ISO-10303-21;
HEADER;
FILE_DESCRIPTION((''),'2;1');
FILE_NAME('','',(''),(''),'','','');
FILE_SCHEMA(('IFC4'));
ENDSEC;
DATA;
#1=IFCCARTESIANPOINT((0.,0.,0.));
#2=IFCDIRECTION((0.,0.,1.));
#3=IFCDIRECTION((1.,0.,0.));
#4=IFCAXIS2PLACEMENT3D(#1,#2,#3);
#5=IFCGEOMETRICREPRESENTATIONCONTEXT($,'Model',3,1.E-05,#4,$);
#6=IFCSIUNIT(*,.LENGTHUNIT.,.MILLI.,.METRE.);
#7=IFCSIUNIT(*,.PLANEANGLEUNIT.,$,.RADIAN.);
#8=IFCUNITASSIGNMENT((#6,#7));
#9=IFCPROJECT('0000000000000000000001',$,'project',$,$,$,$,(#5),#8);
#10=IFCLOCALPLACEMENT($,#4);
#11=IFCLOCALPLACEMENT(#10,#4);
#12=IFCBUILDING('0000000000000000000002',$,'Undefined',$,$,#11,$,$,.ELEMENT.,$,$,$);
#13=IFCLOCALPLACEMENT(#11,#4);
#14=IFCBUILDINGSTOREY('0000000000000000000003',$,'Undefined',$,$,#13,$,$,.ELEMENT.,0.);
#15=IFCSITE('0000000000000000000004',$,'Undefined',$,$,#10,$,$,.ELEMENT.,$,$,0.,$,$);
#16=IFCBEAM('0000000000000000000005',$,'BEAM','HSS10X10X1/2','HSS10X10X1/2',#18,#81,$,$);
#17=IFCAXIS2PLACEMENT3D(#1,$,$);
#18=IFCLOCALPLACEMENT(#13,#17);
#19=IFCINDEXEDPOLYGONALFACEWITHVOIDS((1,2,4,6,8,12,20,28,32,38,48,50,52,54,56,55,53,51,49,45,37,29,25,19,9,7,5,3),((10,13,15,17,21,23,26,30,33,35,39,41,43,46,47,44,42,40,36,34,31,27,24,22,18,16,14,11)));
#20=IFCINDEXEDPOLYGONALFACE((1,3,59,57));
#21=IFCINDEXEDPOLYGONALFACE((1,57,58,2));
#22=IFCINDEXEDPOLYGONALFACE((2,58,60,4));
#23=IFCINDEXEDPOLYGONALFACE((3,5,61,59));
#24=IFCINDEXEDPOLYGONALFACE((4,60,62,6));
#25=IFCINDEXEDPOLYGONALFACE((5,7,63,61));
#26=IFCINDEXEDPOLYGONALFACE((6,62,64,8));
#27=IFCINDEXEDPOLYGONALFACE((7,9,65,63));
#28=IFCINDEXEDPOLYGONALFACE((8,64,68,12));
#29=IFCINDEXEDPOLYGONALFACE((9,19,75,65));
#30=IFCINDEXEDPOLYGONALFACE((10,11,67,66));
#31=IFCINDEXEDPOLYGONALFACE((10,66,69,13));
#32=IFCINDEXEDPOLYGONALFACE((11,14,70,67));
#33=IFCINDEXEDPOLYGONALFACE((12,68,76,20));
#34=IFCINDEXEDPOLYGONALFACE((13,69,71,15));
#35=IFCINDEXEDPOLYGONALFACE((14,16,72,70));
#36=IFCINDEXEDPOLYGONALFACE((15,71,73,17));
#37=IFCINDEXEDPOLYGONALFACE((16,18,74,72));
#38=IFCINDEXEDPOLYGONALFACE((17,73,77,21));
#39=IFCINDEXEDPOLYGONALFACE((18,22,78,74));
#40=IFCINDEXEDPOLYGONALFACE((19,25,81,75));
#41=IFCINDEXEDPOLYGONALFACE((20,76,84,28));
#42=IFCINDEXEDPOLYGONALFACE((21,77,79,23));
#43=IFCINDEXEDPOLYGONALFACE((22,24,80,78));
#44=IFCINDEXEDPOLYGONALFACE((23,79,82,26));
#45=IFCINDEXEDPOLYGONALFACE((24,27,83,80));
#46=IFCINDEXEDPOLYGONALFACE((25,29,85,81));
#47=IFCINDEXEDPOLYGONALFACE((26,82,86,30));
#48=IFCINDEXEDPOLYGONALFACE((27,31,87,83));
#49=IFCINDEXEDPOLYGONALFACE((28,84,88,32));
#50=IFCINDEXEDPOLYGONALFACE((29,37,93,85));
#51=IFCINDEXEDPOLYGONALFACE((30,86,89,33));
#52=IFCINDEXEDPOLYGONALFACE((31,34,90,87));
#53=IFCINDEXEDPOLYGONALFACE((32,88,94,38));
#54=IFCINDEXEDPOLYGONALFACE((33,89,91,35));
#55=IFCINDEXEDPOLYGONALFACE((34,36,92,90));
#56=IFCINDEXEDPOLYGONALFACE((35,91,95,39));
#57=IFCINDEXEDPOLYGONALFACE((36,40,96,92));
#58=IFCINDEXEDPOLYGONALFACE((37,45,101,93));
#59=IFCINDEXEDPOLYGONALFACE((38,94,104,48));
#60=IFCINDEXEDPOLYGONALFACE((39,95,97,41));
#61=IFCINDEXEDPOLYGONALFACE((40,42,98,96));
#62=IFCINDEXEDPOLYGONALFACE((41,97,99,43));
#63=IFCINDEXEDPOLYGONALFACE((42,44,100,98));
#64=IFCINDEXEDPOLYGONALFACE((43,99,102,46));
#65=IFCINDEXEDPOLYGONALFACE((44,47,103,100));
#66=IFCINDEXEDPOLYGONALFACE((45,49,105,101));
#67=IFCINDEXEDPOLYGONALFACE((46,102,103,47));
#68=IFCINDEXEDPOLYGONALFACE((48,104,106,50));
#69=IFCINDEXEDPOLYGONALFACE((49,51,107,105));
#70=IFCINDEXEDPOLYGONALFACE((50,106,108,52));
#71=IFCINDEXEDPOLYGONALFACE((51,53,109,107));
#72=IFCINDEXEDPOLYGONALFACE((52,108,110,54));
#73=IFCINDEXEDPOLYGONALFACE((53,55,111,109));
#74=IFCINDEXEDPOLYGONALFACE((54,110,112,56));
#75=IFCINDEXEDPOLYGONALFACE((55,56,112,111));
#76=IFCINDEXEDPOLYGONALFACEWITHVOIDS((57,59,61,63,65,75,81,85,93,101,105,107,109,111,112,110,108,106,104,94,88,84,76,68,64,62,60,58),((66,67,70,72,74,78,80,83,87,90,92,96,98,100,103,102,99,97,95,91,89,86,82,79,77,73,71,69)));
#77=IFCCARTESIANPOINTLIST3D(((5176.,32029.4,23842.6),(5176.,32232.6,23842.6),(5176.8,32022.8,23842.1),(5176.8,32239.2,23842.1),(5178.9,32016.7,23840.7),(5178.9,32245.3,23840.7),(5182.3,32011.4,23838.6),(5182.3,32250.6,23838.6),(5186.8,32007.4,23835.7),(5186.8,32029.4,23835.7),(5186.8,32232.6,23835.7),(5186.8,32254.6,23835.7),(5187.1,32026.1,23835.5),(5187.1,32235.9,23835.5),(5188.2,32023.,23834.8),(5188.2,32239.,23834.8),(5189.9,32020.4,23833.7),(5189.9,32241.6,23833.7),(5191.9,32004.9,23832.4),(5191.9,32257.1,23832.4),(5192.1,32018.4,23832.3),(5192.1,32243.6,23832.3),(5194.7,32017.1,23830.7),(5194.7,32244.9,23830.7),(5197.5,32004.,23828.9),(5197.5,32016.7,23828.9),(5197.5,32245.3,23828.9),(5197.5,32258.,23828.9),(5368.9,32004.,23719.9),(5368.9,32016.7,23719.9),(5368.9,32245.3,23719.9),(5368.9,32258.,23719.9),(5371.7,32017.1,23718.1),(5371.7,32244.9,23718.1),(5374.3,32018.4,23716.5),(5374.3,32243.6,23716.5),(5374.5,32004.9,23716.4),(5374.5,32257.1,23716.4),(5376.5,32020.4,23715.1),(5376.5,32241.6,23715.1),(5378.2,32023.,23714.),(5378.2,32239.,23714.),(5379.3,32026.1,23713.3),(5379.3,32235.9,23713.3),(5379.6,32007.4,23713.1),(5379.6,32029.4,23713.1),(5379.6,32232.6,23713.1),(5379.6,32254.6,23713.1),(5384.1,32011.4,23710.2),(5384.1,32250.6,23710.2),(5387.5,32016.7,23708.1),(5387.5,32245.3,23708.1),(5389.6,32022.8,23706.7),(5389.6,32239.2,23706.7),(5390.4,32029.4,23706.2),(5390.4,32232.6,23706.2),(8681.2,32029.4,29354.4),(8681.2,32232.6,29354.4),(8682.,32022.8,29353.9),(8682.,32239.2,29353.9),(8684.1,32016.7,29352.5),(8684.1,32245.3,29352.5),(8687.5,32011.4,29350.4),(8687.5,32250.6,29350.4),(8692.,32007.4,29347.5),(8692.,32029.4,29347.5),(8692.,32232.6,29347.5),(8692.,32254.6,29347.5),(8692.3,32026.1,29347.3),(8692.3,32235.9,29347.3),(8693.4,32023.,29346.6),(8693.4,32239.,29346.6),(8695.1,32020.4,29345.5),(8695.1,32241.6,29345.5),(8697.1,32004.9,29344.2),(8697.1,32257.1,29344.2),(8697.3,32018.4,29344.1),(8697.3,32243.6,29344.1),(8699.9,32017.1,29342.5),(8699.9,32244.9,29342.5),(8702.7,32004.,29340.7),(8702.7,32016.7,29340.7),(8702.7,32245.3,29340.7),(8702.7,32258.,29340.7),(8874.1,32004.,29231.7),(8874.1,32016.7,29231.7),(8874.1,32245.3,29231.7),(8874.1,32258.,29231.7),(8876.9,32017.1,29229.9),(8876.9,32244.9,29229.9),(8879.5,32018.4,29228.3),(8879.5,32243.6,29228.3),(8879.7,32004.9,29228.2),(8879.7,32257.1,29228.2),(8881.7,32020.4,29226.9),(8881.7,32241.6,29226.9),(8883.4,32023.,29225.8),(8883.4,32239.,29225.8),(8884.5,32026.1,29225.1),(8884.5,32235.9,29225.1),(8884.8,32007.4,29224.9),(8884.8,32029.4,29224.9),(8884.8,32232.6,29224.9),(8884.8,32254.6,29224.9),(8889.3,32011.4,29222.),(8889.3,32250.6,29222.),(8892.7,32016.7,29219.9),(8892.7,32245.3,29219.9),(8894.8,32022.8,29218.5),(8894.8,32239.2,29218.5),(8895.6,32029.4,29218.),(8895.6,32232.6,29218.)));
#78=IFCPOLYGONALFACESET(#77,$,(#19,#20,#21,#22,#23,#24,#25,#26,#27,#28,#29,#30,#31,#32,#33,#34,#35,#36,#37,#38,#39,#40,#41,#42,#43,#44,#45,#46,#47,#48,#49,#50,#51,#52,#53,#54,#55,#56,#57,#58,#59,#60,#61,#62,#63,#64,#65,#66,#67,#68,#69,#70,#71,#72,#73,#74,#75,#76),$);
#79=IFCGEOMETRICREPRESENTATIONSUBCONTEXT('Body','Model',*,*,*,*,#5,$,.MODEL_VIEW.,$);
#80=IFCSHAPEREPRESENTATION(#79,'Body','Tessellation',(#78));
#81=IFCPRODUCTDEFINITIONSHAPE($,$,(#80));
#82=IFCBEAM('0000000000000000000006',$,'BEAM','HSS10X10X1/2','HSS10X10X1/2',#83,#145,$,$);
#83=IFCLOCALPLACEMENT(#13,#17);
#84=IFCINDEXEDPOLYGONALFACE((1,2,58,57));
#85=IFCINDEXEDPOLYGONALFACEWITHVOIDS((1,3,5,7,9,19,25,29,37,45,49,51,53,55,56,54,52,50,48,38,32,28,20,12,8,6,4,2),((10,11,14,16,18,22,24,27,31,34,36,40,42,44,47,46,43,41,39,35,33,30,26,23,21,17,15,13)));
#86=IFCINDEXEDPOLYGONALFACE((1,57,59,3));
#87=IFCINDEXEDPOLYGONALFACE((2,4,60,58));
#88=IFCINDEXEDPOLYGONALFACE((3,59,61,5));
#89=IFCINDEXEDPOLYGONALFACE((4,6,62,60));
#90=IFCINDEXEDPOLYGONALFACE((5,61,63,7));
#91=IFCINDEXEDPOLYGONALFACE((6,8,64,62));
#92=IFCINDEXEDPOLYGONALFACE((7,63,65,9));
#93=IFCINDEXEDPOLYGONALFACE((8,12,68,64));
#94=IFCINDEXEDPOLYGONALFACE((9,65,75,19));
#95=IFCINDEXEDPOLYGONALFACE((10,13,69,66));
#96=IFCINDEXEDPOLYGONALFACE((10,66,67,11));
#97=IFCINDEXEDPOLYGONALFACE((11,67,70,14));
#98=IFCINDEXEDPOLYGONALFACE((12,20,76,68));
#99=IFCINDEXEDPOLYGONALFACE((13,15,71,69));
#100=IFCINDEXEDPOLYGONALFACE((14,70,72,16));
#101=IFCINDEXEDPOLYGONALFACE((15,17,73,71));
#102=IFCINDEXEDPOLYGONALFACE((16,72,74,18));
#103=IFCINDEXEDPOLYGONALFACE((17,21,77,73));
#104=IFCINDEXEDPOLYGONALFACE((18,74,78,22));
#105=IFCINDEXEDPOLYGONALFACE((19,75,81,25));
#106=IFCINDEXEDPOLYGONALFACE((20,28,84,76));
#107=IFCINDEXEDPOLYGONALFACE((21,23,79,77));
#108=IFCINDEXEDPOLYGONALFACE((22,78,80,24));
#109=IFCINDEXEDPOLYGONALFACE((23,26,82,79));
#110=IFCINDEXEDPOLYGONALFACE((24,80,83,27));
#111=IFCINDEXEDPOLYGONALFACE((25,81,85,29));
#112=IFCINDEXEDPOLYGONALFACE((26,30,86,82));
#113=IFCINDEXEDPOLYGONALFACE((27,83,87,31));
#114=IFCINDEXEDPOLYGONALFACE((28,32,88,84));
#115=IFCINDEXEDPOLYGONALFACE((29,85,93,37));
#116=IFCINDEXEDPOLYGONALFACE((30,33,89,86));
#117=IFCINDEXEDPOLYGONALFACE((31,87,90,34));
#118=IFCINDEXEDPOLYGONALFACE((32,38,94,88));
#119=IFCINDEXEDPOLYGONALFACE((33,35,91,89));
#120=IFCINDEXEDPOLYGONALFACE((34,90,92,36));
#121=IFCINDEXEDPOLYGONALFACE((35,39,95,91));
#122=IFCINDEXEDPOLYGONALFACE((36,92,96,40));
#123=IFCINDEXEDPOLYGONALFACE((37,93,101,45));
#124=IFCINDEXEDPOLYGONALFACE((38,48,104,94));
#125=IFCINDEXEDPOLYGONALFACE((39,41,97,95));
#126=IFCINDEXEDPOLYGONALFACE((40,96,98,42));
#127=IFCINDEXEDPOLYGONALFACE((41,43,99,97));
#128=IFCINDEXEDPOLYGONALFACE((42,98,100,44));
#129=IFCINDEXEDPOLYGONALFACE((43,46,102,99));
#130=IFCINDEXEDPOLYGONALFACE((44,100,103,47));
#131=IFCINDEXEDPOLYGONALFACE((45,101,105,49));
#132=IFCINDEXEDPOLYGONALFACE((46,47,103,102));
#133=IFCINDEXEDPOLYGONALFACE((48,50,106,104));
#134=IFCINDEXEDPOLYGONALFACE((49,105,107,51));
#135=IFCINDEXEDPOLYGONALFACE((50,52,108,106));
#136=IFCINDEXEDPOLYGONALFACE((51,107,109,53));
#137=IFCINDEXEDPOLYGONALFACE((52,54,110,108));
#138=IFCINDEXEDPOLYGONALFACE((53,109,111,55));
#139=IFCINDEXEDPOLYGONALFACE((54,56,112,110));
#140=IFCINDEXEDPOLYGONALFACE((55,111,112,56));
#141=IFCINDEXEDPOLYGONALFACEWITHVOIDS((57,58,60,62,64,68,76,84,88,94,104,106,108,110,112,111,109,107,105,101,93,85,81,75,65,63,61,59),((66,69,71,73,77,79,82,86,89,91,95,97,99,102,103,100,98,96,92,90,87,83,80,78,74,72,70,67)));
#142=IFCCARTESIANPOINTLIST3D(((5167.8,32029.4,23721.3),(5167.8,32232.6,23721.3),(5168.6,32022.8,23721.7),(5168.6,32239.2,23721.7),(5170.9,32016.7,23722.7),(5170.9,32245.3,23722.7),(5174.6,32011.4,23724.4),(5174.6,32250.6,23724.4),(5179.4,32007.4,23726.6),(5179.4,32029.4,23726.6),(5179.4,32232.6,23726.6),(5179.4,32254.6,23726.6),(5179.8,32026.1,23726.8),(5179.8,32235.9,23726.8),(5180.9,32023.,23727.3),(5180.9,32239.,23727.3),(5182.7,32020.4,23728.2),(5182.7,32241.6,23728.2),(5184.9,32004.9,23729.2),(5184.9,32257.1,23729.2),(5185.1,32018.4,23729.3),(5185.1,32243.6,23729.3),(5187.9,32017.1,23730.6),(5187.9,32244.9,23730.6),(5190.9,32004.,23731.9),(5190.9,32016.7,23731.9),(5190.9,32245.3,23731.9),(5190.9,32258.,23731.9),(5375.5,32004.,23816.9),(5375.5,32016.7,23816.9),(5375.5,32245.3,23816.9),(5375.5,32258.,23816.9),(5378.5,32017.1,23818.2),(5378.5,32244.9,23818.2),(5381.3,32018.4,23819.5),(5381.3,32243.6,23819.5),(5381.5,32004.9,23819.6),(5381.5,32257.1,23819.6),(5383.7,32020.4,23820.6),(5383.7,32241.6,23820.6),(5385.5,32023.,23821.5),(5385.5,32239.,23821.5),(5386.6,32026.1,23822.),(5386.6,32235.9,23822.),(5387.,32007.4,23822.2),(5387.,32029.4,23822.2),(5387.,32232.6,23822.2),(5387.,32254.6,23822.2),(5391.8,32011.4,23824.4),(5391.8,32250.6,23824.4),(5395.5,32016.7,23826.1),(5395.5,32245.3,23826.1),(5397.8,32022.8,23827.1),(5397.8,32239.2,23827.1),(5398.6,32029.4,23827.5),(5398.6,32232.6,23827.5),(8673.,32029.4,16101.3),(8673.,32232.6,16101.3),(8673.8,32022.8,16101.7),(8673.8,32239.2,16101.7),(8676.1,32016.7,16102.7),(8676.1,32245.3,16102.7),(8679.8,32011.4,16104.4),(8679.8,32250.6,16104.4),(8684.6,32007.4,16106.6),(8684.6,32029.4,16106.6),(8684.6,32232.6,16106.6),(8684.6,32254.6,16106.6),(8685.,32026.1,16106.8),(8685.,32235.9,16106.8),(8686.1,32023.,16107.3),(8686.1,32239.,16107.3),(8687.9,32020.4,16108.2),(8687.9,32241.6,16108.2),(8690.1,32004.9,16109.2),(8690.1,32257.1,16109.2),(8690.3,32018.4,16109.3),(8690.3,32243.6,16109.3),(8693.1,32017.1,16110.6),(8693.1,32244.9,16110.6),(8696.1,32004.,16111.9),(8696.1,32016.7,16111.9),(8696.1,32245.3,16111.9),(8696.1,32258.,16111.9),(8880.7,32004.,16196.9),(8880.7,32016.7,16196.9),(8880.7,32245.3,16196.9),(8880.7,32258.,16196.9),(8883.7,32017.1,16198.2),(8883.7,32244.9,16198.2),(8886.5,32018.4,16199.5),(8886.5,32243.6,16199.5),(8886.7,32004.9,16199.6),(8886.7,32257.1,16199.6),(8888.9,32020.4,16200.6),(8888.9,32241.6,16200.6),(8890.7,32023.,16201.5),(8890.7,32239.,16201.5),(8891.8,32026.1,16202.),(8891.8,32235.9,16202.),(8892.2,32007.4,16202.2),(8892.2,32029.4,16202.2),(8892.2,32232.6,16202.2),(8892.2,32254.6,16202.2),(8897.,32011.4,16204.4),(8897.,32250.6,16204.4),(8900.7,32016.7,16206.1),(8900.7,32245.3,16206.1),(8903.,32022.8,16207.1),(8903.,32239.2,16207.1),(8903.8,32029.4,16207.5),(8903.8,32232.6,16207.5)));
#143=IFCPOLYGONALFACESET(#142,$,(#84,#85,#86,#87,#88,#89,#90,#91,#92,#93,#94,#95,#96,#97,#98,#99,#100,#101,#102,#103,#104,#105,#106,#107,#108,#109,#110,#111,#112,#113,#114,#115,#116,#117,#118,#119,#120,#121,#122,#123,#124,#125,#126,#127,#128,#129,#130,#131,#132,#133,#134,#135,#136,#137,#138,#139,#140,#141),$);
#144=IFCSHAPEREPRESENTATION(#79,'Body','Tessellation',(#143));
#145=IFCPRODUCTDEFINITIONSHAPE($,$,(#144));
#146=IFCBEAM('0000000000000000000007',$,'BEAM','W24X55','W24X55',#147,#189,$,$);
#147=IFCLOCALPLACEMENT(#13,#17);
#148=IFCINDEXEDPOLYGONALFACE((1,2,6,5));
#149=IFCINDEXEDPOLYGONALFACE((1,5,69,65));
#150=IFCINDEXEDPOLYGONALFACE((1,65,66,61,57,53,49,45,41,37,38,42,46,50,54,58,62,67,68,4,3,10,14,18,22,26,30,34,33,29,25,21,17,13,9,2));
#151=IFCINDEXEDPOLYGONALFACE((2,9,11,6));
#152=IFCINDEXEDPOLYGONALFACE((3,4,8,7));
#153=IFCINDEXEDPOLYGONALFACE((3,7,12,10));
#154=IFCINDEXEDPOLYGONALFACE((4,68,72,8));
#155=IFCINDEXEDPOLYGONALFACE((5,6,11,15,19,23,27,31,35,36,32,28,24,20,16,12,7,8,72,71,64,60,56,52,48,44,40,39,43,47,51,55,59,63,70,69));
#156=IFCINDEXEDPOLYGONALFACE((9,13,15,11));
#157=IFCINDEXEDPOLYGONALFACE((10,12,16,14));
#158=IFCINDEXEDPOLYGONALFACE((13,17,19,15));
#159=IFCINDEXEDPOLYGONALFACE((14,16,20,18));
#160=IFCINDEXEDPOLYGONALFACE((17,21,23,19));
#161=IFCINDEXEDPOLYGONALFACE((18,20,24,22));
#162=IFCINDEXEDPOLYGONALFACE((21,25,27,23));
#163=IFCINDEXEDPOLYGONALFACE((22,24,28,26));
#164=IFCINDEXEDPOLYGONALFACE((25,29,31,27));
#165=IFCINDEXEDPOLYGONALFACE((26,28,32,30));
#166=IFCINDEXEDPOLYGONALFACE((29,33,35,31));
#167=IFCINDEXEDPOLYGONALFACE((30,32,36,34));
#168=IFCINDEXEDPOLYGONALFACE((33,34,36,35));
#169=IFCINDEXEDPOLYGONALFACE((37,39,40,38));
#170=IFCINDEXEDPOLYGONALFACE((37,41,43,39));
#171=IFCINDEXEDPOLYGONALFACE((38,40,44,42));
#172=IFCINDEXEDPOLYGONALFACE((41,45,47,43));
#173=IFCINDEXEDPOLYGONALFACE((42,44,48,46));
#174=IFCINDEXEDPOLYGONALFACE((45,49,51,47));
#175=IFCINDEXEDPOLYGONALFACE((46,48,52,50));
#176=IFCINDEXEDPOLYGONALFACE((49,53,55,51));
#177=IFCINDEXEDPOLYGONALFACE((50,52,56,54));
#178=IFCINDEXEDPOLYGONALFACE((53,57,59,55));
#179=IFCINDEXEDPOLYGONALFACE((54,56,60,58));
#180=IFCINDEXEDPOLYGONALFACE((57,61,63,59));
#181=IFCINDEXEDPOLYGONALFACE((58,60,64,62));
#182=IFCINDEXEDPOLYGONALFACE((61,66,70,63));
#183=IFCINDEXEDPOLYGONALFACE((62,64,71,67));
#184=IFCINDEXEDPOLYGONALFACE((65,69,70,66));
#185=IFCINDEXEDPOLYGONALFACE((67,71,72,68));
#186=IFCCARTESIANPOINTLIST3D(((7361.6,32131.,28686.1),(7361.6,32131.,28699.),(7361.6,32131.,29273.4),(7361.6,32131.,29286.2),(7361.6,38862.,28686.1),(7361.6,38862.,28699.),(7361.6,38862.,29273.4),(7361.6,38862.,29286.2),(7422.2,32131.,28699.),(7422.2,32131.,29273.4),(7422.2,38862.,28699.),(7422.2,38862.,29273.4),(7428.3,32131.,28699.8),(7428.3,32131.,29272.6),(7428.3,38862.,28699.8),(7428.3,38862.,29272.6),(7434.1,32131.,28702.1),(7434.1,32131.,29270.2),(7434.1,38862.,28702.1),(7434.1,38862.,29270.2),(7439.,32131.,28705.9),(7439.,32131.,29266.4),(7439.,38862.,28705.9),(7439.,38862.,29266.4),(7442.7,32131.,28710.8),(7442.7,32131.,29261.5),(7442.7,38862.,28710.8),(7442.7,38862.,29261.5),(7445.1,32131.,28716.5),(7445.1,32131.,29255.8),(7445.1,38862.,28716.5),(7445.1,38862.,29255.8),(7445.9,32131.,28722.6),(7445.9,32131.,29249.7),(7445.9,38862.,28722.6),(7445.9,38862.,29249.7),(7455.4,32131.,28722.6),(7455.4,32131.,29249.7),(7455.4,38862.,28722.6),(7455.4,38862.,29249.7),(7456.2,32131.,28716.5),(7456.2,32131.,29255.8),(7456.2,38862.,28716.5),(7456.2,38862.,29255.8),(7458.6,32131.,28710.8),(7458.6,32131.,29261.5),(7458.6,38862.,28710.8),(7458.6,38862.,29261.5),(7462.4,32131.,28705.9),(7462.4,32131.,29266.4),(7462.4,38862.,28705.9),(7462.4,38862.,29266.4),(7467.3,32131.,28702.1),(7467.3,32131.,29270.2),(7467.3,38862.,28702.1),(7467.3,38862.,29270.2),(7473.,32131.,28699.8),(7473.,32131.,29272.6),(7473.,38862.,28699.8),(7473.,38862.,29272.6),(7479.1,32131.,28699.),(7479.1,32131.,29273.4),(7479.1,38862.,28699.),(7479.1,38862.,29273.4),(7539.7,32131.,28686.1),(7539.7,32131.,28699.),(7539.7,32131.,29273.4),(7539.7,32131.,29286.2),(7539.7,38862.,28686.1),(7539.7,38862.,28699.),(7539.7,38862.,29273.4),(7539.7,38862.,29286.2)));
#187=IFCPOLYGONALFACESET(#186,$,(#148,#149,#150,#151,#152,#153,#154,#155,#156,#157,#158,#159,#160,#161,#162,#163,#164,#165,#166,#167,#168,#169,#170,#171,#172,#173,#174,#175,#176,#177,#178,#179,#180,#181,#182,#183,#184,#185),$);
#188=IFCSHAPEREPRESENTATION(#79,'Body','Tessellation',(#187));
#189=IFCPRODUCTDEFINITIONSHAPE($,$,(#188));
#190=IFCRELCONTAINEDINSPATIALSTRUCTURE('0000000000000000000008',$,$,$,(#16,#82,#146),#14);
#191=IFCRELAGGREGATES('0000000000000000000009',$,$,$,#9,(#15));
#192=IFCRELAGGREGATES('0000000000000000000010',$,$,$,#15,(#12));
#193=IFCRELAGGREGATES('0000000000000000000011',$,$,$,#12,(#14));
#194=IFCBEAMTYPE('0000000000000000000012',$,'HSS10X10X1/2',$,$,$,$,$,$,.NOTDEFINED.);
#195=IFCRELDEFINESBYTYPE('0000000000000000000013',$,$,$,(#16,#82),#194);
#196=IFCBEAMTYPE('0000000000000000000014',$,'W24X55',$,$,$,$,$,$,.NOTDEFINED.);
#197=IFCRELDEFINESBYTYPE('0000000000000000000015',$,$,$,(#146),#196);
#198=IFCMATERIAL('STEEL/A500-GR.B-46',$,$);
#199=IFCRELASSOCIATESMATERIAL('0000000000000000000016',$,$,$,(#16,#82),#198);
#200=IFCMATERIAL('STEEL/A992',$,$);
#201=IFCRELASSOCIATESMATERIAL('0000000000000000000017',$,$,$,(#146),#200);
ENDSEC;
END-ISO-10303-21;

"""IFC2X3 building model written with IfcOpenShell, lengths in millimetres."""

from ifc_helpers import new_model, si_unit, frame, origin_with_axes, origin_2d_with_axis, place, context, subcontext, project, spatial, hollow_rectangle, i_section, extrude, material, type_object, element, save


model = new_model("IFC2X3")

# Units and contexts
model_context = context("Model", 3, precision=1e-05, world=origin_with_axes())
body_context = subcontext(model_context, "Body", "Model", "MODEL_VIEW")
ifc_project = project(units=[si_unit("LENGTHUNIT", "METRE", prefix="MILLI"), si_unit("PLANEANGLEUNIT", "RADIAN")], contexts=[model_context])

# Site, building, storey
site_placement = place(None, origin_with_axes())
site = spatial("IfcSite", under=ifc_project, at=site_placement, Name="Undefined", CompositionType="ELEMENT", RefElevation=0.0)
building_placement = place(site_placement, origin_with_axes())
building = spatial("IfcBuilding", under=site, at=building_placement, Name="Undefined", CompositionType="ELEMENT")
storey_placement = place(building_placement, origin_with_axes())
storey = spatial("IfcBuildingStorey", under=building, at=storey_placement, Name="Undefined", CompositionType="ELEMENT", Elevation=0.0)

# Shared definitions
ifc_material_1 = material(Name="STEEL/A992")

# Beams
ifc_material_2 = material(Name="STEEL/A500-GR.B-46")
beam_type_1 = type_object("IfcBeamType", Name="HSS10X10X1/2", PredefinedType="NOTDEFINED")
beam_1_placement = place(storey_placement, frame((5283.2, 32131.0, 23774.4), z_axis=(-0.843822, 0.0, 0.536624), x_axis=(0.536624, 0.0, 0.843822)))
element("IfcBeam", 1, at=beam_1_placement, inside=storey, type_object=beam_type_1, material=ifc_material_2, Name="BEAM", Description="HSS10X10X1/2", ObjectType="HSS10X10X1/2", context=body_context, shape_type="SweptSolid", body=[
    extrude(hollow_rectangle(XDim=254.0, YDim=254.0, WallThickness=12.7, InnerFilletRadius=12.7, OuterFilletRadius=25.4, at=origin_2d_with_axis()), frame((6531.9, 0.0, 0.0), z_axis=(-1.0, 0.0, 0.0), x_axis=(0.0, -1.0, 0.0)), (0.0, 0.0, 1.0), 6531.9),
])
beam_2_placement = place(storey_placement, frame((8788.4, 32131.0, 16154.4), z_axis=(0.908491, 0.0, 0.417905), x_axis=(-0.417905, 0.0, 0.908491)))
element("IfcBeam", 2, at=beam_2_placement, inside=storey, type_object=beam_type_1, material=ifc_material_2, Name="BEAM", Description="HSS10X10X1/2", ObjectType="HSS10X10X1/2", context=body_context, shape_type="SweptSolid", body=[
    extrude(hollow_rectangle(XDim=254.0, YDim=254.0, WallThickness=12.7, InnerFilletRadius=12.7, OuterFilletRadius=25.4, at=origin_2d_with_axis()), frame((8387.5, 0.0, 0.0), z_axis=(-1.0, 0.0, 0.0), x_axis=(0.0, -1.0, 0.0)), (0.0, 0.0, 1.0), 8387.5),
])
beam_type_2 = type_object("IfcBeamType", Name="W24X55", PredefinedType="NOTDEFINED")
for number, where, z_axis, x_axis, name in (
    (3, (7450.7, 32131.0, 28986.2), (0.0, 0.0, 1.0), (0.0, 1.0, 0.0), "BEAM"),
):
    element("IfcBeam", number, at=place(storey_placement, frame(where, z_axis=z_axis, x_axis=x_axis)), inside=storey, type_object=beam_type_2, material=ifc_material_1, Name=name, Description="W24X55", ObjectType="W24X55", context=body_context, shape_type="SweptSolid", body=[
        extrude(i_section(OverallWidth=178.1, OverallDepth=600.1, WebThickness=9.5, FlangeThickness=12.8, FilletRadius=23.7, at=origin_2d_with_axis()), frame((6731.0, 0.0, 0.0), z_axis=(-1.0, 0.0, 0.0), x_axis=(0.0, -1.0, 0.0)), (0.0, 0.0, 1.0), 6731.0),
    ])

save(model, "model.ifc")
